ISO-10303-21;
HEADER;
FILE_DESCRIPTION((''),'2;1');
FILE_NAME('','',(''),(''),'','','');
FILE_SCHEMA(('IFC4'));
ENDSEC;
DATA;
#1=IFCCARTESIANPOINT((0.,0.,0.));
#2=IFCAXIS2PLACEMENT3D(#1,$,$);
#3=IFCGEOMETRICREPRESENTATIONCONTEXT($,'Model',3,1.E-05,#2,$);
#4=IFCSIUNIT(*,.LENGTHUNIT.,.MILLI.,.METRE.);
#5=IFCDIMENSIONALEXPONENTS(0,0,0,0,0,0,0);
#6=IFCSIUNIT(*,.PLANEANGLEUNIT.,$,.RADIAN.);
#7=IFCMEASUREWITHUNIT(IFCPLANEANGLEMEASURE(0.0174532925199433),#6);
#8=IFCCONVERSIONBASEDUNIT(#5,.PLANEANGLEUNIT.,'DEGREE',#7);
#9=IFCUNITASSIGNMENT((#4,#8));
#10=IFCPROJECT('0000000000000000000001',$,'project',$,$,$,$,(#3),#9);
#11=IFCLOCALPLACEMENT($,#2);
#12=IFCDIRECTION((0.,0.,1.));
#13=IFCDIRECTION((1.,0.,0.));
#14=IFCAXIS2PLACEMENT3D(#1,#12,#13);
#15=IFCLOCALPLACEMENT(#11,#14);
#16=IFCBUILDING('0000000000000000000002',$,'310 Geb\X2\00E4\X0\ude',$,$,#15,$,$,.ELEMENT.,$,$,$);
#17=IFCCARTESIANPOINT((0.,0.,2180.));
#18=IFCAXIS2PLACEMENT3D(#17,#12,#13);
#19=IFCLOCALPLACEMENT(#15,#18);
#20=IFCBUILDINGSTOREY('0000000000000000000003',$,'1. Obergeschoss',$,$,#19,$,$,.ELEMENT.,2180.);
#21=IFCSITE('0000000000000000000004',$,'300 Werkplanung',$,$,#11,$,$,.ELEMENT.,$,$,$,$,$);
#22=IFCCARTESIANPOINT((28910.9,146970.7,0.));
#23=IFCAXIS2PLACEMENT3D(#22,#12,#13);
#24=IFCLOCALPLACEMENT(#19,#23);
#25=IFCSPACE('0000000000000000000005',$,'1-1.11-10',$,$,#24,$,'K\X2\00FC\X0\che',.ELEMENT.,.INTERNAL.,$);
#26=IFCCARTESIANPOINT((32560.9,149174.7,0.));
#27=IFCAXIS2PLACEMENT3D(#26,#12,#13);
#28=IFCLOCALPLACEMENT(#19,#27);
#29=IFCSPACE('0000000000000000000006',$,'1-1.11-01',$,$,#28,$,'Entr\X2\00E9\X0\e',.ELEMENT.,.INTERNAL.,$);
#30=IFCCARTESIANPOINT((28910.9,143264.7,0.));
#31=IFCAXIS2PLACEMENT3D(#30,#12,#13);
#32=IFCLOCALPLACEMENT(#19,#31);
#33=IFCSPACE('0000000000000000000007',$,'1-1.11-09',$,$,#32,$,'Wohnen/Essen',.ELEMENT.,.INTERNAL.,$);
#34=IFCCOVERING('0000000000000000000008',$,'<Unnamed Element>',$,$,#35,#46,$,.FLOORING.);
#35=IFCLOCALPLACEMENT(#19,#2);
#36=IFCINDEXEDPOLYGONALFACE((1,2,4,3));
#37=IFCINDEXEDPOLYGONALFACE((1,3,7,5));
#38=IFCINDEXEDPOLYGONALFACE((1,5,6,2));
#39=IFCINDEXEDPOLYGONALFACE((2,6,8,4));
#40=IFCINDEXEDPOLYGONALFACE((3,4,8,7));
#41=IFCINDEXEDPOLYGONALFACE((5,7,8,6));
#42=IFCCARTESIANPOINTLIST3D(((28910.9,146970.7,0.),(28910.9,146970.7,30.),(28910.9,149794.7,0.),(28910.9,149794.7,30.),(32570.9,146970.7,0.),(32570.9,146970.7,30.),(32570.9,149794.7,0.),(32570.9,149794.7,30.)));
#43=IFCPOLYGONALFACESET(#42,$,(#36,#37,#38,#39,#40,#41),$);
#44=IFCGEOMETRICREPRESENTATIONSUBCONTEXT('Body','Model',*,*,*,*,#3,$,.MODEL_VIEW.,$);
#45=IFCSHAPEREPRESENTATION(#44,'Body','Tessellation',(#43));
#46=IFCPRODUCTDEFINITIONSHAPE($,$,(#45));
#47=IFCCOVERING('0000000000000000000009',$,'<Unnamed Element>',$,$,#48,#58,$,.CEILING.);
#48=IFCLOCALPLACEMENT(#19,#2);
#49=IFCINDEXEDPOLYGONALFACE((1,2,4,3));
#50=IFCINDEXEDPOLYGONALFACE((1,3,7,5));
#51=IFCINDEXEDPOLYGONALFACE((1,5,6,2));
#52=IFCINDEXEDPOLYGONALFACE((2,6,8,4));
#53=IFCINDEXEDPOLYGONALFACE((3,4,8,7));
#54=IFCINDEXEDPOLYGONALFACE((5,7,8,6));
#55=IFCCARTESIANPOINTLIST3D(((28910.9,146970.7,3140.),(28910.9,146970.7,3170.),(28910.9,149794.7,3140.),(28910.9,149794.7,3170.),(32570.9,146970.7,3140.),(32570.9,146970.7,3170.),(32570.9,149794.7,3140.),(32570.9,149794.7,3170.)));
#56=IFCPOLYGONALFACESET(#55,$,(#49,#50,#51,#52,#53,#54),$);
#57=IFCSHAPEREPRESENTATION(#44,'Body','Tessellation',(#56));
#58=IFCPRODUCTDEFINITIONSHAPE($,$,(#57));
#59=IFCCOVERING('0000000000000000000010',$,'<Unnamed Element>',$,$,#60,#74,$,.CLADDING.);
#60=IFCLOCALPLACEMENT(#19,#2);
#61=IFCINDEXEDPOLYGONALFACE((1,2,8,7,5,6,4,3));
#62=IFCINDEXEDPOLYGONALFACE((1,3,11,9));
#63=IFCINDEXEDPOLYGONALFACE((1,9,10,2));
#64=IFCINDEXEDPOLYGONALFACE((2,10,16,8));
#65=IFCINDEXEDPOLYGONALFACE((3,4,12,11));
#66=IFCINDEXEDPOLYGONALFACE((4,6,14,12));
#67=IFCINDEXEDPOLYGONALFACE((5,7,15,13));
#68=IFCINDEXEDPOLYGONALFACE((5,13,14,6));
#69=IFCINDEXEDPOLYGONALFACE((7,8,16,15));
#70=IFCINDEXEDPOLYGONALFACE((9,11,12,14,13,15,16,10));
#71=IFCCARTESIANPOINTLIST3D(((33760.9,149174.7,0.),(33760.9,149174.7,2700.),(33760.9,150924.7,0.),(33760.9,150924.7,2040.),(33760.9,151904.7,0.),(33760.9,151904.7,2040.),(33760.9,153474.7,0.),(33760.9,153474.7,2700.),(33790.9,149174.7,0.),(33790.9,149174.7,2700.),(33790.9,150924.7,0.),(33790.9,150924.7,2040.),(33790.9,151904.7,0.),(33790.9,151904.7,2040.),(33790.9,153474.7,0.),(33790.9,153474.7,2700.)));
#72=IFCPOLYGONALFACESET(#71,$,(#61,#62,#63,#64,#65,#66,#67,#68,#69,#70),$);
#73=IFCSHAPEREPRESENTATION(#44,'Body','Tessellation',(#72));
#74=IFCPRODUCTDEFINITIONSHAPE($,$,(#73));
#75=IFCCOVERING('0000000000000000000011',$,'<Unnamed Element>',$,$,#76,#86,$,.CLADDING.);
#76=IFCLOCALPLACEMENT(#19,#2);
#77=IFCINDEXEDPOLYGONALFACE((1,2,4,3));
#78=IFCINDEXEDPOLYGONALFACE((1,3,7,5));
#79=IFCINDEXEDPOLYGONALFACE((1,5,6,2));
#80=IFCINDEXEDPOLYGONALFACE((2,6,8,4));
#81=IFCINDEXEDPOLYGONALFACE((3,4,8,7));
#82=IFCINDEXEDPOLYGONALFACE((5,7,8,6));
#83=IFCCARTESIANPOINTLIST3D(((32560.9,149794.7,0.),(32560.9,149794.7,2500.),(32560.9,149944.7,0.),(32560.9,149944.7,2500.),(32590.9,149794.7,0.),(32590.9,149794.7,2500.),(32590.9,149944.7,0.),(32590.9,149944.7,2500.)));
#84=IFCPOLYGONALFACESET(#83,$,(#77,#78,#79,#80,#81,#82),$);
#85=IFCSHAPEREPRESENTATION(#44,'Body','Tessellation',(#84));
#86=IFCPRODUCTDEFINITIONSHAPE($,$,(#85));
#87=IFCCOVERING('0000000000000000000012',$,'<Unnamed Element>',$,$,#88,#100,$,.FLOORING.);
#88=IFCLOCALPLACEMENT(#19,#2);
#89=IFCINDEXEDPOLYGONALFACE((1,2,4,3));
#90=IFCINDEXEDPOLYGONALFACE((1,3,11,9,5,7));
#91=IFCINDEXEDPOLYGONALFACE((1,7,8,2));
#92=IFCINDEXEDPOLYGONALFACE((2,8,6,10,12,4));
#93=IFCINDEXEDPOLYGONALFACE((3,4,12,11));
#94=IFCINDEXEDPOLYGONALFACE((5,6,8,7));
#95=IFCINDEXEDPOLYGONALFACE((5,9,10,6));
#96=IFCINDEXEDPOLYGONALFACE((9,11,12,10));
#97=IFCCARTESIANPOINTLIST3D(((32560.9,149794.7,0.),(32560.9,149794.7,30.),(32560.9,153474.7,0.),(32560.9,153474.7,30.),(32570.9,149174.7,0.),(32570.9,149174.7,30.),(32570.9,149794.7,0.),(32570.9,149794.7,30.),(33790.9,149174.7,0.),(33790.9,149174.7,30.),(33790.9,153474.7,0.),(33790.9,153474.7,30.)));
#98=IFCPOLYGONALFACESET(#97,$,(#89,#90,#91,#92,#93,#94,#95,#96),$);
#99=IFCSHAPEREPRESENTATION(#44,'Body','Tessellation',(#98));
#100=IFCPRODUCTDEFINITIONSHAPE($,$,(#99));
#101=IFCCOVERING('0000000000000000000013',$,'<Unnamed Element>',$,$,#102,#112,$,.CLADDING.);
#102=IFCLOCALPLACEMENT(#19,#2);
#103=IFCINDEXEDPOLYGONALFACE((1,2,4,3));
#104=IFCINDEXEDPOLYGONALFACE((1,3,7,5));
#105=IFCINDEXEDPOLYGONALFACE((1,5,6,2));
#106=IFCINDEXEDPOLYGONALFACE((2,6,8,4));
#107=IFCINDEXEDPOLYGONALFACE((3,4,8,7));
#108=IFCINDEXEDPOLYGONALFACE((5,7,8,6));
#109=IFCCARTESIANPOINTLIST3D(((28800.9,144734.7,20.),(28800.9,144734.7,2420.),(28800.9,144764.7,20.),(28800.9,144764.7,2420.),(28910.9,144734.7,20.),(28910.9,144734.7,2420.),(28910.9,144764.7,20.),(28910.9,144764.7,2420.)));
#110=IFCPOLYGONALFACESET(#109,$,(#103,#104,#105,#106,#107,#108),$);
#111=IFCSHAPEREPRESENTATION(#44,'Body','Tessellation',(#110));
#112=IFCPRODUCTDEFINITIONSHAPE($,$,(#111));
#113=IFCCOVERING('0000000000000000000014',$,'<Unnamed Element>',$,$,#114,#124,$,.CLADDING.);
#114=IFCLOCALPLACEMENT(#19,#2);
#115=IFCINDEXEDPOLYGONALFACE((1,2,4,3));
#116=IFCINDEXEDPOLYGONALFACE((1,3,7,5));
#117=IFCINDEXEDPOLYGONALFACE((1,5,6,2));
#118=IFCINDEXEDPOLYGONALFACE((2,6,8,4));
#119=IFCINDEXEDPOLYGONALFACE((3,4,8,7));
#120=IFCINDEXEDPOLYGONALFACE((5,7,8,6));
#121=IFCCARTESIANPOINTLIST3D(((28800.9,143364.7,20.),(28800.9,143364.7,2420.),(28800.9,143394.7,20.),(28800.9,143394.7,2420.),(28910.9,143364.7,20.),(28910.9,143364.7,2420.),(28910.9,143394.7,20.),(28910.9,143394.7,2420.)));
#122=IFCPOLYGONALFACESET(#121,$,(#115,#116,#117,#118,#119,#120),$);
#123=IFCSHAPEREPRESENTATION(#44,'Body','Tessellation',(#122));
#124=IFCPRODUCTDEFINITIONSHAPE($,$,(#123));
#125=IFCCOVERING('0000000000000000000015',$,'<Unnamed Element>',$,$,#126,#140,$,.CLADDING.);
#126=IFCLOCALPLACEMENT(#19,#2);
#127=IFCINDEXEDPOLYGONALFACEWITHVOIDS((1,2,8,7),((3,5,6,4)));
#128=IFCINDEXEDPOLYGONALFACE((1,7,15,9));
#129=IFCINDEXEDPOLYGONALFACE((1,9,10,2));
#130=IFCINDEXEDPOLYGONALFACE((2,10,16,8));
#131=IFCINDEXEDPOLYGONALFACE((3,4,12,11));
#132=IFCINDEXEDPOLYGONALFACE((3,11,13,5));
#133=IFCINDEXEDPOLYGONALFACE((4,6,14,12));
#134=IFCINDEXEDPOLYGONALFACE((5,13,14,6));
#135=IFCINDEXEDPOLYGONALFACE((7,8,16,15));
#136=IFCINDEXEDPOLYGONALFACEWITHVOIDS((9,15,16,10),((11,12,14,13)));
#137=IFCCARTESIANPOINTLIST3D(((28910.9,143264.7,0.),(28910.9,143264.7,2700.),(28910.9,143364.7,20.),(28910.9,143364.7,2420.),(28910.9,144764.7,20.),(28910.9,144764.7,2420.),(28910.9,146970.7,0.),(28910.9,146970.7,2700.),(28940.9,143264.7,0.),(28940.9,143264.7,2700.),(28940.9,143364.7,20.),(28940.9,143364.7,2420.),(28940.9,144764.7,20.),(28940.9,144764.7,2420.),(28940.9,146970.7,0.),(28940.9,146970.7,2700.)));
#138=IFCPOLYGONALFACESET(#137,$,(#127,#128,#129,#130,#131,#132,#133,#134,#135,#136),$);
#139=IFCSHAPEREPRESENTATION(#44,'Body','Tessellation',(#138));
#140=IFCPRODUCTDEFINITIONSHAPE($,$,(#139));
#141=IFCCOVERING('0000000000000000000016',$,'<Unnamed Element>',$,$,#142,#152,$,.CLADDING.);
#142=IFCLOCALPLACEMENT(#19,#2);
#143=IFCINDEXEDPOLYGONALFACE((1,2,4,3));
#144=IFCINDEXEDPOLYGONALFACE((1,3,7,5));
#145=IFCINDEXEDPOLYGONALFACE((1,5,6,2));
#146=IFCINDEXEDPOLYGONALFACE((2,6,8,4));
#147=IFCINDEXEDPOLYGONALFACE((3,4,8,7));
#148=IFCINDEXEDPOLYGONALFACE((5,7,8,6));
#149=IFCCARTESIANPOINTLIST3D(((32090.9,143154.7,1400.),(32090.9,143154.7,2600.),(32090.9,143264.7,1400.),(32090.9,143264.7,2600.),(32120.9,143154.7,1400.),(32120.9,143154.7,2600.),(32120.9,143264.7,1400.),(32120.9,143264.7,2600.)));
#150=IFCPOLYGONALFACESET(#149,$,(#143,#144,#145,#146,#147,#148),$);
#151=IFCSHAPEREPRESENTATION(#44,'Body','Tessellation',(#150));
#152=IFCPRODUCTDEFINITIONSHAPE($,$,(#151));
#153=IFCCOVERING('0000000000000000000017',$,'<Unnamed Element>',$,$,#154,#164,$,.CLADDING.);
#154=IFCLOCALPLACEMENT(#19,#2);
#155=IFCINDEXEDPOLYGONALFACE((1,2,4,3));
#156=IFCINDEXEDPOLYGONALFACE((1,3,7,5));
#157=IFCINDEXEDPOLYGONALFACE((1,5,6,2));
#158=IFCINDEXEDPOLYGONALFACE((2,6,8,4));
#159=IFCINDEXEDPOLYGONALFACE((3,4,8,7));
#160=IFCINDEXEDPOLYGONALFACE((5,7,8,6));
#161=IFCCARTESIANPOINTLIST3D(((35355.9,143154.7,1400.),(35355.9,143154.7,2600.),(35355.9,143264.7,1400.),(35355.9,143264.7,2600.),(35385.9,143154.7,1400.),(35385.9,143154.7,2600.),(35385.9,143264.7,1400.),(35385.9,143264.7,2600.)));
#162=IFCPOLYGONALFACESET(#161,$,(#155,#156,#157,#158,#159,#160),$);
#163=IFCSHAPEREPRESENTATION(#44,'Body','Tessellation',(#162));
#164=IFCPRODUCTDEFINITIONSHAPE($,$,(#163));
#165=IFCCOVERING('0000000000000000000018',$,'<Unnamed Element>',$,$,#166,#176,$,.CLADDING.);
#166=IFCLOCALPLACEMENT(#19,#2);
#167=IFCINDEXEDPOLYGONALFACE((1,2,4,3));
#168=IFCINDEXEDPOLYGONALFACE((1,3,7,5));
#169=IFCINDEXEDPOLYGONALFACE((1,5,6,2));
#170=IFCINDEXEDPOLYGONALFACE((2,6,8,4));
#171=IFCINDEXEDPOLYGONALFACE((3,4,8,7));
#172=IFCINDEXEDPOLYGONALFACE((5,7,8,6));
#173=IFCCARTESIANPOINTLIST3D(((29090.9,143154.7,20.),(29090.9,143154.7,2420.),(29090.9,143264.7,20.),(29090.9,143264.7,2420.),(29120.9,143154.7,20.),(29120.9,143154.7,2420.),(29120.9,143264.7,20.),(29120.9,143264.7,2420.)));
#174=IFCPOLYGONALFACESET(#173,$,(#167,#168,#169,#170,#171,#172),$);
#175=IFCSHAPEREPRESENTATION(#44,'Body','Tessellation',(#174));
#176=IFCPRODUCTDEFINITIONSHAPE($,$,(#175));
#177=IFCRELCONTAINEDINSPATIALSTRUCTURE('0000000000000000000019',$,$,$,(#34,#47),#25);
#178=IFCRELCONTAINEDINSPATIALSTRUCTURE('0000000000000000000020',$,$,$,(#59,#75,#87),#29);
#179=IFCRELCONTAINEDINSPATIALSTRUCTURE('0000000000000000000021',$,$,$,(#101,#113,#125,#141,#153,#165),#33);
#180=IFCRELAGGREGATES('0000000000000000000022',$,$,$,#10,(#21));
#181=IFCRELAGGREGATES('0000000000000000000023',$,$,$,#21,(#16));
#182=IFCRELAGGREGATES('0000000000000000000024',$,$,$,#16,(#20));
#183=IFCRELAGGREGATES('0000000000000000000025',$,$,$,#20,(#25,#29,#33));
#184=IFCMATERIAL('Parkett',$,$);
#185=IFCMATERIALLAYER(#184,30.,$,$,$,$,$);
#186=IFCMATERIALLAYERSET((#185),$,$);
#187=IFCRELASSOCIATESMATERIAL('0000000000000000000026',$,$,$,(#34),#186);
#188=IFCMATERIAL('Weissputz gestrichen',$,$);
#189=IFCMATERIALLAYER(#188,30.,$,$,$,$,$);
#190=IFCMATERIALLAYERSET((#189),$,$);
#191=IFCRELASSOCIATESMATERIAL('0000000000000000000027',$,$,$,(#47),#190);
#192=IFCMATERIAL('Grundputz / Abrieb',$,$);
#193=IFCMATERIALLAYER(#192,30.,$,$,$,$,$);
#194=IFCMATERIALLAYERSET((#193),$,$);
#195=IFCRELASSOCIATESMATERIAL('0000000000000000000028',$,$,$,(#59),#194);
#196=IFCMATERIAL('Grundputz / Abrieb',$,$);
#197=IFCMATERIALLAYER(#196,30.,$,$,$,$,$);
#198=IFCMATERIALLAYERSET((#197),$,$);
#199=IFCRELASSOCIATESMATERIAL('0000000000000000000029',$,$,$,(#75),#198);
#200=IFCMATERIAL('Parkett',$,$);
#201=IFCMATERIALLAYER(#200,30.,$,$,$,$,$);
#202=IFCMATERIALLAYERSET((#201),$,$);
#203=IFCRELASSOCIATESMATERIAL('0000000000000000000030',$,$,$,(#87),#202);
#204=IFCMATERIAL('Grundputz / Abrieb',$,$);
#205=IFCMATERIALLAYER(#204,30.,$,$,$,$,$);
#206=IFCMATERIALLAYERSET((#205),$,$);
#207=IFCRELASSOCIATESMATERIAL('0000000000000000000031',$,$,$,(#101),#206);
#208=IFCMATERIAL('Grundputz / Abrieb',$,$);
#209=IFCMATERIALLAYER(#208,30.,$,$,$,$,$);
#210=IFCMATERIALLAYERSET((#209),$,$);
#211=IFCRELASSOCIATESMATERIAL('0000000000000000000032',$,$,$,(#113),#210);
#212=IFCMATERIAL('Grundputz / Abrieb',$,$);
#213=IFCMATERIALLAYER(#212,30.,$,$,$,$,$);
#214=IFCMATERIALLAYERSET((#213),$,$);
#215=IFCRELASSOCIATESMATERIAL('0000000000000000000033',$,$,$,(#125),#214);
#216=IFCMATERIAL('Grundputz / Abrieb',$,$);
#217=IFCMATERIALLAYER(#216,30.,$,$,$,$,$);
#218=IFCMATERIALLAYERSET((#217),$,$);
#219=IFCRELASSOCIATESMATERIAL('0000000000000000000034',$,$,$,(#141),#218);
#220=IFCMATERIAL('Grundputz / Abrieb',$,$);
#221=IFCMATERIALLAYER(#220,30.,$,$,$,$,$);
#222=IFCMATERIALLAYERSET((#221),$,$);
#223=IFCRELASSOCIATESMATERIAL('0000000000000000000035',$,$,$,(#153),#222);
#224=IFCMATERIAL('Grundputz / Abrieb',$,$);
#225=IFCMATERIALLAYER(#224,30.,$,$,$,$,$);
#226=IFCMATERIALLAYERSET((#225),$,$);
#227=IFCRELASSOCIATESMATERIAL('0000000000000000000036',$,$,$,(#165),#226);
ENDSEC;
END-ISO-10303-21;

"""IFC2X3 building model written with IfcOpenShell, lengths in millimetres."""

from ifc_helpers import new_model, entity, si_unit, converted_unit, frame, frame_2d, origin, origin_with_axes, place, context, subcontext, project, spatial, polyline, rectangle, outline, extrude, material, layer, layer_set, layer_usage, element, save


model = new_model("IFC2X3")

# Units and contexts
model_context = context("Model", 3, precision=1e-05, world=origin())
body_context = subcontext(model_context, "Body", "Model", "MODEL_VIEW")
ifc_project = project(units=[si_unit("LENGTHUNIT", "METRE", prefix="MILLI"), converted_unit("PLANEANGLEUNIT", "DEGREE", entity("IfcPlaneAngleMeasure", 0.0174532925199433), si_unit("PLANEANGLEUNIT", "RADIAN"), dimensions=[0, 0, 0, 0, 0, 0, 0])], contexts=[model_context])

# Site, building, storey
site_placement = place(None, origin())
site = spatial("IfcSite", under=ifc_project, at=site_placement, Name="300 Werkplanung", CompositionType="ELEMENT")
building_placement = place(site_placement, origin_with_axes())
building = spatial("IfcBuilding", under=site, at=building_placement, Name="310 Gebäude", CompositionType="ELEMENT")
storey_placement = place(building_placement, frame((0.0, 0.0, 2180.0), z_axis=(0.0, 0.0, 1.0), x_axis=(1.0, 0.0, 0.0)))
storey = spatial("IfcBuildingStorey", under=building, at=storey_placement, Name="1. Obergeschoss", CompositionType="ELEMENT", Elevation=2180.0)

# Shared definitions
space_1_placement = place(storey_placement, frame((28910.9, 146970.7, 0.0), z_axis=(0.0, 0.0, 1.0), x_axis=(1.0, 0.0, 0.0)))
space_1 = spatial("IfcSpace", under=storey, at=space_1_placement, Name="1-1.11-10", LongName="Küche", CompositionType="ELEMENT", InteriorOrExteriorSpace="INTERNAL")

# Coverings
ifc_material_1 = material(Name="Parkett")
ifc_layer_1 = layer(ifc_material_1, 30.0)
ifc_layer_set_1 = layer_set([ifc_layer_1])
ifc_layer_usage_1 = layer_usage(ifc_layer_set_1, "AXIS3", "POSITIVE", 0.0)
covering_1_placement = place(space_1_placement, origin_with_axes())
element("IfcCovering", 1, at=covering_1_placement, inside=space_1, material=ifc_layer_usage_1, Name="<Unnamed Element>", PredefinedType="FLOORING", context=body_context, shape_type="SweptSolid", body=[
    extrude(rectangle(XDim=2824.0, YDim=3660.0, at=frame_2d((-1830.0, 1412.0), x_axis=(0.0, 1.0))), frame((3660.0, 0.0, 0.0), z_axis=(0.0, 0.0, 1.0), x_axis=(1.0, 0.0, 0.0)), (0.0, 0.0, 1.0), 30.0),
])
ifc_material_2 = material(Name="Weissputz gestrichen")
ifc_layer_2 = layer(ifc_material_2, 30.0)
ifc_layer_set_2 = layer_set([ifc_layer_2])
ifc_layer_usage_2 = layer_usage(ifc_layer_set_2, "AXIS3", "POSITIVE", 0.0)
covering_2_placement = place(space_1_placement, frame((1830.0, 1412.0, 3170.0), z_axis=(0.0, 0.0, -1.0), x_axis=(1.0, 0.0, 0.0)))
element("IfcCovering", 2, at=covering_2_placement, inside=space_1, material=ifc_layer_usage_2, Name="<Unnamed Element>", PredefinedType="CEILING", context=body_context, shape_type="SweptSolid", body=[
    extrude(rectangle(XDim=2824.0, YDim=3660.0, at=frame_2d((-1830.0, 1412.0), x_axis=(0.0, 1.0))), frame((1830.0, -1412.0, 0.0), z_axis=(0.0, 0.0, 1.0), x_axis=(1.0, 0.0, 0.0)), (0.0, 0.0, 1.0), 30.0),
])

# Shared definitions
space_2_placement = place(storey_placement, frame((32560.9, 149174.7, 0.0), z_axis=(0.0, 0.0, 1.0), x_axis=(1.0, 0.0, 0.0)))
space_2 = spatial("IfcSpace", under=storey, at=space_2_placement, Name="1-1.11-01", LongName="Entrée", CompositionType="ELEMENT", InteriorOrExteriorSpace="INTERNAL")

# Coverings
ifc_material_3 = material(Name="Grundputz / Abrieb")
ifc_layer_3 = layer(ifc_material_3, 30.0)
ifc_layer_set_3 = layer_set([ifc_layer_3])
ifc_layer_usage_3 = layer_usage(ifc_layer_set_3, "AXIS3", "POSITIVE", 0.0)
covering_3_placement = place(space_2_placement, frame((1230.0, 0.0, 0.0), z_axis=(0.0, 0.0, 1.0), x_axis=(0.0, 1.0, 0.0)))
element("IfcCovering", 3, at=covering_3_placement, inside=space_2, material=ifc_layer_usage_3, Name="<Unnamed Element>", PredefinedType="CLADDING", context=body_context, shape_type="SweptSolid", body=[
    extrude(outline(polyline([(0.0, -2700.0), (0.0, 0.0), (1750.0, 0.0), (1750.0, -2040.0), (2730.0, -2040.0), (2730.0, 0.0), (4300.0, 0.0), (4300.0, -2700.0), (0.0, -2700.0)])), frame((0.0, 0.0, 0.0), z_axis=(0.0, 1.0, 0.0), x_axis=(1.0, 0.0, 0.0)), (0.0, 0.0, 1.0), 30.0),
])
ifc_material_4 = material(Name="Grundputz / Abrieb")
ifc_layer_4 = layer(ifc_material_4, 30.0)
ifc_layer_set_4 = layer_set([ifc_layer_4])
ifc_layer_usage_4 = layer_usage(ifc_layer_set_4, "AXIS3", "POSITIVE", 0.0)
covering_4_placement = place(space_2_placement, frame((0.0, 770.0, 0.0), z_axis=(0.0, 0.0, 1.0), x_axis=(0.0, -1.0, 0.0)))
element("IfcCovering", 4, at=covering_4_placement, inside=space_2, material=ifc_layer_usage_4, Name="<Unnamed Element>", PredefinedType="CLADDING", context=body_context, shape_type="SweptSolid", body=[
    extrude(rectangle(XDim=2500.0, YDim=150.0, at=frame_2d((-75.0, 1250.0), x_axis=(0.0, 1.0))), frame((150.0, 0.0, 2500.0), z_axis=(0.0, 1.0, 0.0), x_axis=(1.0, 0.0, 0.0)), (0.0, 0.0, 1.0), 30.0),
])
ifc_material_5 = material(Name="Parkett")
ifc_layer_5 = layer(ifc_material_5, 30.0)
ifc_layer_set_5 = layer_set([ifc_layer_5])
ifc_layer_usage_5 = layer_usage(ifc_layer_set_5, "AXIS3", "POSITIVE", 0.0)
covering_5_placement = place(space_2_placement, origin_with_axes())
element("IfcCovering", 5, at=covering_5_placement, inside=space_2, material=ifc_layer_usage_5, Name="<Unnamed Element>", PredefinedType="FLOORING", context=body_context, shape_type="SweptSolid", body=[
    extrude(outline(polyline([(1230.0, 4300.0), (0.0, 4300.0), (0.0, 620.0), (10.0, 620.0), (10.0, 0.0), (1230.0, 0.0), (1230.0, 4300.0)])), origin_with_axes(), (0.0, 0.0, 1.0), 30.0),
])

# Shared definitions
space_3_placement = place(storey_placement, frame((28910.9, 143264.7, 0.0), z_axis=(0.0, 0.0, 1.0), x_axis=(1.0, 0.0, 0.0)))
space_3 = spatial("IfcSpace", under=storey, at=space_3_placement, Name="1-1.11-09", LongName="Wohnen/Essen", CompositionType="ELEMENT", InteriorOrExteriorSpace="INTERNAL")

# Coverings
ifc_material_6 = material(Name="Grundputz / Abrieb")
ifc_layer_6 = layer(ifc_material_6, 30.0)
ifc_layer_set_6 = layer_set([ifc_layer_6])
ifc_layer_usage_6 = layer_usage(ifc_layer_set_6, "AXIS3", "POSITIVE", 0.0)
covering_6_placement = place(space_3_placement, frame((0.0, 1500.0, 20.0), z_axis=(0.0, 0.0, 1.0), x_axis=(-1.0, 0.0, 0.0)))
element("IfcCovering", 6, at=covering_6_placement, inside=space_3, material=ifc_layer_usage_6, Name="<Unnamed Element>", PredefinedType="CLADDING", context=body_context, shape_type="SweptSolid", body=[
    extrude(rectangle(XDim=2400.0, YDim=110.0, at=frame_2d((-55.0, 1200.0), x_axis=(0.0, 1.0))), frame((110.0, 0.0, 2400.0), z_axis=(0.0, 1.0, 0.0), x_axis=(1.0, 0.0, 0.0)), (0.0, 0.0, 1.0), 30.0),
])
ifc_material_7 = material(Name="Grundputz / Abrieb")
ifc_layer_7 = layer(ifc_material_7, 30.0)
ifc_layer_set_7 = layer_set([ifc_layer_7])
ifc_layer_usage_7 = layer_usage(ifc_layer_set_7, "AXIS3", "POSITIVE", 0.0)
covering_7_placement = place(space_3_placement, frame((-110.0, 100.0, 20.0), z_axis=(0.0, 0.0, 1.0), x_axis=(1.0, 0.0, 0.0)))
element("IfcCovering", 7, at=covering_7_placement, inside=space_3, material=ifc_layer_usage_7, Name="<Unnamed Element>", PredefinedType="CLADDING", context=body_context, shape_type="SweptSolid", body=[
    extrude(rectangle(XDim=2400.0, YDim=110.0, at=frame_2d((-55.0, 1200.0), x_axis=(0.0, 1.0))), frame((110.0, 0.0, 2400.0), z_axis=(0.0, 1.0, 0.0), x_axis=(1.0, 0.0, 0.0)), (0.0, 0.0, 1.0), 30.0),
])
ifc_material_8 = material(Name="Grundputz / Abrieb")
ifc_layer_8 = layer(ifc_material_8, 30.0)
ifc_layer_set_8 = layer_set([ifc_layer_8])
ifc_layer_usage_8 = layer_usage(ifc_layer_set_8, "AXIS3", "POSITIVE", 0.0)
covering_8_placement = place(space_3_placement, frame((0.0, 3706.0, 0.0), z_axis=(0.0, 0.0, 1.0), x_axis=(0.0, -1.0, 0.0)))
element("IfcCovering", 8, at=covering_8_placement, inside=space_3, material=ifc_layer_usage_8, Name="<Unnamed Element>", PredefinedType="CLADDING", context=body_context, shape_type="SweptSolid", body=[
    extrude(outline(polyline([(3706.0, 0.0), (3706.0, -2700.0), (0.0, -2700.0), (0.0, 0.0), (3706.0, 0.0)]), holes=[polyline([(3606.0, -20.0), (2206.0, -20.0), (2206.0, -2420.0), (3606.0, -2420.0), (3606.0, -20.0)])]), frame((0.0, 0.0, 0.0), z_axis=(0.0, 1.0, 0.0), x_axis=(1.0, 0.0, 0.0)), (0.0, 0.0, 1.0), 30.0),
])
ifc_material_9 = material(Name="Grundputz / Abrieb")
ifc_layer_9 = layer(ifc_material_9, 30.0)
ifc_layer_set_9 = layer_set([ifc_layer_9])
ifc_layer_usage_9 = layer_usage(ifc_layer_set_9, "AXIS3", "POSITIVE", 0.0)
covering_9_placement = place(space_3_placement, frame((3180.0, 0.0, 1400.0), z_axis=(0.0, 0.0, 1.0), x_axis=(0.0, -1.0, 0.0)))
element("IfcCovering", 9, at=covering_9_placement, inside=space_3, material=ifc_layer_usage_9, Name="<Unnamed Element>", PredefinedType="CLADDING", context=body_context, shape_type="SweptSolid", body=[
    extrude(rectangle(XDim=1200.0, YDim=110.0, at=frame_2d((-55.0, 600.0), x_axis=(0.0, 1.0))), frame((110.0, 0.0, 1200.0), z_axis=(0.0, 1.0, 0.0), x_axis=(1.0, 0.0, 0.0)), (0.0, 0.0, 1.0), 30.0),
])
ifc_material_10 = material(Name="Grundputz / Abrieb")
ifc_layer_10 = layer(ifc_material_10, 30.0)
ifc_layer_set_10 = layer_set([ifc_layer_10])
ifc_layer_usage_10 = layer_usage(ifc_layer_set_10, "AXIS3", "POSITIVE", 0.0)
covering_10_placement = place(space_3_placement, frame((6475.0, -110.0, 1400.0), z_axis=(0.0, 0.0, 1.0), x_axis=(0.0, 1.0, 0.0)))
element("IfcCovering", 10, at=covering_10_placement, inside=space_3, material=ifc_layer_usage_10, Name="<Unnamed Element>", PredefinedType="CLADDING", context=body_context, shape_type="SweptSolid", body=[
    extrude(rectangle(XDim=1200.0, YDim=110.0, at=frame_2d((-55.0, 600.0), x_axis=(0.0, 1.0))), frame((110.0, 0.0, 1200.0), z_axis=(0.0, 1.0, 0.0), x_axis=(1.0, 0.0, 0.0)), (0.0, 0.0, 1.0), 30.0),
])
ifc_material_11 = material(Name="Grundputz / Abrieb")
ifc_layer_11 = layer(ifc_material_11, 30.0)
ifc_layer_set_11 = layer_set([ifc_layer_11])
ifc_layer_usage_11 = layer_usage(ifc_layer_set_11, "AXIS3", "POSITIVE", 0.0)
covering_11_placement = place(space_3_placement, frame((180.0, 0.0, 20.0), z_axis=(0.0, 0.0, 1.0), x_axis=(0.0, -1.0, 0.0)))
element("IfcCovering", 11, at=covering_11_placement, inside=space_3, material=ifc_layer_usage_11, Name="<Unnamed Element>", PredefinedType="CLADDING", context=body_context, shape_type="SweptSolid", body=[
    extrude(rectangle(XDim=2400.0, YDim=110.0, at=frame_2d((-55.0, 1200.0), x_axis=(0.0, 1.0))), frame((110.0, 0.0, 2400.0), z_axis=(0.0, 1.0, 0.0), x_axis=(1.0, 0.0, 0.0)), (0.0, 0.0, 1.0), 30.0),
])

save(model, "model.ifc")
